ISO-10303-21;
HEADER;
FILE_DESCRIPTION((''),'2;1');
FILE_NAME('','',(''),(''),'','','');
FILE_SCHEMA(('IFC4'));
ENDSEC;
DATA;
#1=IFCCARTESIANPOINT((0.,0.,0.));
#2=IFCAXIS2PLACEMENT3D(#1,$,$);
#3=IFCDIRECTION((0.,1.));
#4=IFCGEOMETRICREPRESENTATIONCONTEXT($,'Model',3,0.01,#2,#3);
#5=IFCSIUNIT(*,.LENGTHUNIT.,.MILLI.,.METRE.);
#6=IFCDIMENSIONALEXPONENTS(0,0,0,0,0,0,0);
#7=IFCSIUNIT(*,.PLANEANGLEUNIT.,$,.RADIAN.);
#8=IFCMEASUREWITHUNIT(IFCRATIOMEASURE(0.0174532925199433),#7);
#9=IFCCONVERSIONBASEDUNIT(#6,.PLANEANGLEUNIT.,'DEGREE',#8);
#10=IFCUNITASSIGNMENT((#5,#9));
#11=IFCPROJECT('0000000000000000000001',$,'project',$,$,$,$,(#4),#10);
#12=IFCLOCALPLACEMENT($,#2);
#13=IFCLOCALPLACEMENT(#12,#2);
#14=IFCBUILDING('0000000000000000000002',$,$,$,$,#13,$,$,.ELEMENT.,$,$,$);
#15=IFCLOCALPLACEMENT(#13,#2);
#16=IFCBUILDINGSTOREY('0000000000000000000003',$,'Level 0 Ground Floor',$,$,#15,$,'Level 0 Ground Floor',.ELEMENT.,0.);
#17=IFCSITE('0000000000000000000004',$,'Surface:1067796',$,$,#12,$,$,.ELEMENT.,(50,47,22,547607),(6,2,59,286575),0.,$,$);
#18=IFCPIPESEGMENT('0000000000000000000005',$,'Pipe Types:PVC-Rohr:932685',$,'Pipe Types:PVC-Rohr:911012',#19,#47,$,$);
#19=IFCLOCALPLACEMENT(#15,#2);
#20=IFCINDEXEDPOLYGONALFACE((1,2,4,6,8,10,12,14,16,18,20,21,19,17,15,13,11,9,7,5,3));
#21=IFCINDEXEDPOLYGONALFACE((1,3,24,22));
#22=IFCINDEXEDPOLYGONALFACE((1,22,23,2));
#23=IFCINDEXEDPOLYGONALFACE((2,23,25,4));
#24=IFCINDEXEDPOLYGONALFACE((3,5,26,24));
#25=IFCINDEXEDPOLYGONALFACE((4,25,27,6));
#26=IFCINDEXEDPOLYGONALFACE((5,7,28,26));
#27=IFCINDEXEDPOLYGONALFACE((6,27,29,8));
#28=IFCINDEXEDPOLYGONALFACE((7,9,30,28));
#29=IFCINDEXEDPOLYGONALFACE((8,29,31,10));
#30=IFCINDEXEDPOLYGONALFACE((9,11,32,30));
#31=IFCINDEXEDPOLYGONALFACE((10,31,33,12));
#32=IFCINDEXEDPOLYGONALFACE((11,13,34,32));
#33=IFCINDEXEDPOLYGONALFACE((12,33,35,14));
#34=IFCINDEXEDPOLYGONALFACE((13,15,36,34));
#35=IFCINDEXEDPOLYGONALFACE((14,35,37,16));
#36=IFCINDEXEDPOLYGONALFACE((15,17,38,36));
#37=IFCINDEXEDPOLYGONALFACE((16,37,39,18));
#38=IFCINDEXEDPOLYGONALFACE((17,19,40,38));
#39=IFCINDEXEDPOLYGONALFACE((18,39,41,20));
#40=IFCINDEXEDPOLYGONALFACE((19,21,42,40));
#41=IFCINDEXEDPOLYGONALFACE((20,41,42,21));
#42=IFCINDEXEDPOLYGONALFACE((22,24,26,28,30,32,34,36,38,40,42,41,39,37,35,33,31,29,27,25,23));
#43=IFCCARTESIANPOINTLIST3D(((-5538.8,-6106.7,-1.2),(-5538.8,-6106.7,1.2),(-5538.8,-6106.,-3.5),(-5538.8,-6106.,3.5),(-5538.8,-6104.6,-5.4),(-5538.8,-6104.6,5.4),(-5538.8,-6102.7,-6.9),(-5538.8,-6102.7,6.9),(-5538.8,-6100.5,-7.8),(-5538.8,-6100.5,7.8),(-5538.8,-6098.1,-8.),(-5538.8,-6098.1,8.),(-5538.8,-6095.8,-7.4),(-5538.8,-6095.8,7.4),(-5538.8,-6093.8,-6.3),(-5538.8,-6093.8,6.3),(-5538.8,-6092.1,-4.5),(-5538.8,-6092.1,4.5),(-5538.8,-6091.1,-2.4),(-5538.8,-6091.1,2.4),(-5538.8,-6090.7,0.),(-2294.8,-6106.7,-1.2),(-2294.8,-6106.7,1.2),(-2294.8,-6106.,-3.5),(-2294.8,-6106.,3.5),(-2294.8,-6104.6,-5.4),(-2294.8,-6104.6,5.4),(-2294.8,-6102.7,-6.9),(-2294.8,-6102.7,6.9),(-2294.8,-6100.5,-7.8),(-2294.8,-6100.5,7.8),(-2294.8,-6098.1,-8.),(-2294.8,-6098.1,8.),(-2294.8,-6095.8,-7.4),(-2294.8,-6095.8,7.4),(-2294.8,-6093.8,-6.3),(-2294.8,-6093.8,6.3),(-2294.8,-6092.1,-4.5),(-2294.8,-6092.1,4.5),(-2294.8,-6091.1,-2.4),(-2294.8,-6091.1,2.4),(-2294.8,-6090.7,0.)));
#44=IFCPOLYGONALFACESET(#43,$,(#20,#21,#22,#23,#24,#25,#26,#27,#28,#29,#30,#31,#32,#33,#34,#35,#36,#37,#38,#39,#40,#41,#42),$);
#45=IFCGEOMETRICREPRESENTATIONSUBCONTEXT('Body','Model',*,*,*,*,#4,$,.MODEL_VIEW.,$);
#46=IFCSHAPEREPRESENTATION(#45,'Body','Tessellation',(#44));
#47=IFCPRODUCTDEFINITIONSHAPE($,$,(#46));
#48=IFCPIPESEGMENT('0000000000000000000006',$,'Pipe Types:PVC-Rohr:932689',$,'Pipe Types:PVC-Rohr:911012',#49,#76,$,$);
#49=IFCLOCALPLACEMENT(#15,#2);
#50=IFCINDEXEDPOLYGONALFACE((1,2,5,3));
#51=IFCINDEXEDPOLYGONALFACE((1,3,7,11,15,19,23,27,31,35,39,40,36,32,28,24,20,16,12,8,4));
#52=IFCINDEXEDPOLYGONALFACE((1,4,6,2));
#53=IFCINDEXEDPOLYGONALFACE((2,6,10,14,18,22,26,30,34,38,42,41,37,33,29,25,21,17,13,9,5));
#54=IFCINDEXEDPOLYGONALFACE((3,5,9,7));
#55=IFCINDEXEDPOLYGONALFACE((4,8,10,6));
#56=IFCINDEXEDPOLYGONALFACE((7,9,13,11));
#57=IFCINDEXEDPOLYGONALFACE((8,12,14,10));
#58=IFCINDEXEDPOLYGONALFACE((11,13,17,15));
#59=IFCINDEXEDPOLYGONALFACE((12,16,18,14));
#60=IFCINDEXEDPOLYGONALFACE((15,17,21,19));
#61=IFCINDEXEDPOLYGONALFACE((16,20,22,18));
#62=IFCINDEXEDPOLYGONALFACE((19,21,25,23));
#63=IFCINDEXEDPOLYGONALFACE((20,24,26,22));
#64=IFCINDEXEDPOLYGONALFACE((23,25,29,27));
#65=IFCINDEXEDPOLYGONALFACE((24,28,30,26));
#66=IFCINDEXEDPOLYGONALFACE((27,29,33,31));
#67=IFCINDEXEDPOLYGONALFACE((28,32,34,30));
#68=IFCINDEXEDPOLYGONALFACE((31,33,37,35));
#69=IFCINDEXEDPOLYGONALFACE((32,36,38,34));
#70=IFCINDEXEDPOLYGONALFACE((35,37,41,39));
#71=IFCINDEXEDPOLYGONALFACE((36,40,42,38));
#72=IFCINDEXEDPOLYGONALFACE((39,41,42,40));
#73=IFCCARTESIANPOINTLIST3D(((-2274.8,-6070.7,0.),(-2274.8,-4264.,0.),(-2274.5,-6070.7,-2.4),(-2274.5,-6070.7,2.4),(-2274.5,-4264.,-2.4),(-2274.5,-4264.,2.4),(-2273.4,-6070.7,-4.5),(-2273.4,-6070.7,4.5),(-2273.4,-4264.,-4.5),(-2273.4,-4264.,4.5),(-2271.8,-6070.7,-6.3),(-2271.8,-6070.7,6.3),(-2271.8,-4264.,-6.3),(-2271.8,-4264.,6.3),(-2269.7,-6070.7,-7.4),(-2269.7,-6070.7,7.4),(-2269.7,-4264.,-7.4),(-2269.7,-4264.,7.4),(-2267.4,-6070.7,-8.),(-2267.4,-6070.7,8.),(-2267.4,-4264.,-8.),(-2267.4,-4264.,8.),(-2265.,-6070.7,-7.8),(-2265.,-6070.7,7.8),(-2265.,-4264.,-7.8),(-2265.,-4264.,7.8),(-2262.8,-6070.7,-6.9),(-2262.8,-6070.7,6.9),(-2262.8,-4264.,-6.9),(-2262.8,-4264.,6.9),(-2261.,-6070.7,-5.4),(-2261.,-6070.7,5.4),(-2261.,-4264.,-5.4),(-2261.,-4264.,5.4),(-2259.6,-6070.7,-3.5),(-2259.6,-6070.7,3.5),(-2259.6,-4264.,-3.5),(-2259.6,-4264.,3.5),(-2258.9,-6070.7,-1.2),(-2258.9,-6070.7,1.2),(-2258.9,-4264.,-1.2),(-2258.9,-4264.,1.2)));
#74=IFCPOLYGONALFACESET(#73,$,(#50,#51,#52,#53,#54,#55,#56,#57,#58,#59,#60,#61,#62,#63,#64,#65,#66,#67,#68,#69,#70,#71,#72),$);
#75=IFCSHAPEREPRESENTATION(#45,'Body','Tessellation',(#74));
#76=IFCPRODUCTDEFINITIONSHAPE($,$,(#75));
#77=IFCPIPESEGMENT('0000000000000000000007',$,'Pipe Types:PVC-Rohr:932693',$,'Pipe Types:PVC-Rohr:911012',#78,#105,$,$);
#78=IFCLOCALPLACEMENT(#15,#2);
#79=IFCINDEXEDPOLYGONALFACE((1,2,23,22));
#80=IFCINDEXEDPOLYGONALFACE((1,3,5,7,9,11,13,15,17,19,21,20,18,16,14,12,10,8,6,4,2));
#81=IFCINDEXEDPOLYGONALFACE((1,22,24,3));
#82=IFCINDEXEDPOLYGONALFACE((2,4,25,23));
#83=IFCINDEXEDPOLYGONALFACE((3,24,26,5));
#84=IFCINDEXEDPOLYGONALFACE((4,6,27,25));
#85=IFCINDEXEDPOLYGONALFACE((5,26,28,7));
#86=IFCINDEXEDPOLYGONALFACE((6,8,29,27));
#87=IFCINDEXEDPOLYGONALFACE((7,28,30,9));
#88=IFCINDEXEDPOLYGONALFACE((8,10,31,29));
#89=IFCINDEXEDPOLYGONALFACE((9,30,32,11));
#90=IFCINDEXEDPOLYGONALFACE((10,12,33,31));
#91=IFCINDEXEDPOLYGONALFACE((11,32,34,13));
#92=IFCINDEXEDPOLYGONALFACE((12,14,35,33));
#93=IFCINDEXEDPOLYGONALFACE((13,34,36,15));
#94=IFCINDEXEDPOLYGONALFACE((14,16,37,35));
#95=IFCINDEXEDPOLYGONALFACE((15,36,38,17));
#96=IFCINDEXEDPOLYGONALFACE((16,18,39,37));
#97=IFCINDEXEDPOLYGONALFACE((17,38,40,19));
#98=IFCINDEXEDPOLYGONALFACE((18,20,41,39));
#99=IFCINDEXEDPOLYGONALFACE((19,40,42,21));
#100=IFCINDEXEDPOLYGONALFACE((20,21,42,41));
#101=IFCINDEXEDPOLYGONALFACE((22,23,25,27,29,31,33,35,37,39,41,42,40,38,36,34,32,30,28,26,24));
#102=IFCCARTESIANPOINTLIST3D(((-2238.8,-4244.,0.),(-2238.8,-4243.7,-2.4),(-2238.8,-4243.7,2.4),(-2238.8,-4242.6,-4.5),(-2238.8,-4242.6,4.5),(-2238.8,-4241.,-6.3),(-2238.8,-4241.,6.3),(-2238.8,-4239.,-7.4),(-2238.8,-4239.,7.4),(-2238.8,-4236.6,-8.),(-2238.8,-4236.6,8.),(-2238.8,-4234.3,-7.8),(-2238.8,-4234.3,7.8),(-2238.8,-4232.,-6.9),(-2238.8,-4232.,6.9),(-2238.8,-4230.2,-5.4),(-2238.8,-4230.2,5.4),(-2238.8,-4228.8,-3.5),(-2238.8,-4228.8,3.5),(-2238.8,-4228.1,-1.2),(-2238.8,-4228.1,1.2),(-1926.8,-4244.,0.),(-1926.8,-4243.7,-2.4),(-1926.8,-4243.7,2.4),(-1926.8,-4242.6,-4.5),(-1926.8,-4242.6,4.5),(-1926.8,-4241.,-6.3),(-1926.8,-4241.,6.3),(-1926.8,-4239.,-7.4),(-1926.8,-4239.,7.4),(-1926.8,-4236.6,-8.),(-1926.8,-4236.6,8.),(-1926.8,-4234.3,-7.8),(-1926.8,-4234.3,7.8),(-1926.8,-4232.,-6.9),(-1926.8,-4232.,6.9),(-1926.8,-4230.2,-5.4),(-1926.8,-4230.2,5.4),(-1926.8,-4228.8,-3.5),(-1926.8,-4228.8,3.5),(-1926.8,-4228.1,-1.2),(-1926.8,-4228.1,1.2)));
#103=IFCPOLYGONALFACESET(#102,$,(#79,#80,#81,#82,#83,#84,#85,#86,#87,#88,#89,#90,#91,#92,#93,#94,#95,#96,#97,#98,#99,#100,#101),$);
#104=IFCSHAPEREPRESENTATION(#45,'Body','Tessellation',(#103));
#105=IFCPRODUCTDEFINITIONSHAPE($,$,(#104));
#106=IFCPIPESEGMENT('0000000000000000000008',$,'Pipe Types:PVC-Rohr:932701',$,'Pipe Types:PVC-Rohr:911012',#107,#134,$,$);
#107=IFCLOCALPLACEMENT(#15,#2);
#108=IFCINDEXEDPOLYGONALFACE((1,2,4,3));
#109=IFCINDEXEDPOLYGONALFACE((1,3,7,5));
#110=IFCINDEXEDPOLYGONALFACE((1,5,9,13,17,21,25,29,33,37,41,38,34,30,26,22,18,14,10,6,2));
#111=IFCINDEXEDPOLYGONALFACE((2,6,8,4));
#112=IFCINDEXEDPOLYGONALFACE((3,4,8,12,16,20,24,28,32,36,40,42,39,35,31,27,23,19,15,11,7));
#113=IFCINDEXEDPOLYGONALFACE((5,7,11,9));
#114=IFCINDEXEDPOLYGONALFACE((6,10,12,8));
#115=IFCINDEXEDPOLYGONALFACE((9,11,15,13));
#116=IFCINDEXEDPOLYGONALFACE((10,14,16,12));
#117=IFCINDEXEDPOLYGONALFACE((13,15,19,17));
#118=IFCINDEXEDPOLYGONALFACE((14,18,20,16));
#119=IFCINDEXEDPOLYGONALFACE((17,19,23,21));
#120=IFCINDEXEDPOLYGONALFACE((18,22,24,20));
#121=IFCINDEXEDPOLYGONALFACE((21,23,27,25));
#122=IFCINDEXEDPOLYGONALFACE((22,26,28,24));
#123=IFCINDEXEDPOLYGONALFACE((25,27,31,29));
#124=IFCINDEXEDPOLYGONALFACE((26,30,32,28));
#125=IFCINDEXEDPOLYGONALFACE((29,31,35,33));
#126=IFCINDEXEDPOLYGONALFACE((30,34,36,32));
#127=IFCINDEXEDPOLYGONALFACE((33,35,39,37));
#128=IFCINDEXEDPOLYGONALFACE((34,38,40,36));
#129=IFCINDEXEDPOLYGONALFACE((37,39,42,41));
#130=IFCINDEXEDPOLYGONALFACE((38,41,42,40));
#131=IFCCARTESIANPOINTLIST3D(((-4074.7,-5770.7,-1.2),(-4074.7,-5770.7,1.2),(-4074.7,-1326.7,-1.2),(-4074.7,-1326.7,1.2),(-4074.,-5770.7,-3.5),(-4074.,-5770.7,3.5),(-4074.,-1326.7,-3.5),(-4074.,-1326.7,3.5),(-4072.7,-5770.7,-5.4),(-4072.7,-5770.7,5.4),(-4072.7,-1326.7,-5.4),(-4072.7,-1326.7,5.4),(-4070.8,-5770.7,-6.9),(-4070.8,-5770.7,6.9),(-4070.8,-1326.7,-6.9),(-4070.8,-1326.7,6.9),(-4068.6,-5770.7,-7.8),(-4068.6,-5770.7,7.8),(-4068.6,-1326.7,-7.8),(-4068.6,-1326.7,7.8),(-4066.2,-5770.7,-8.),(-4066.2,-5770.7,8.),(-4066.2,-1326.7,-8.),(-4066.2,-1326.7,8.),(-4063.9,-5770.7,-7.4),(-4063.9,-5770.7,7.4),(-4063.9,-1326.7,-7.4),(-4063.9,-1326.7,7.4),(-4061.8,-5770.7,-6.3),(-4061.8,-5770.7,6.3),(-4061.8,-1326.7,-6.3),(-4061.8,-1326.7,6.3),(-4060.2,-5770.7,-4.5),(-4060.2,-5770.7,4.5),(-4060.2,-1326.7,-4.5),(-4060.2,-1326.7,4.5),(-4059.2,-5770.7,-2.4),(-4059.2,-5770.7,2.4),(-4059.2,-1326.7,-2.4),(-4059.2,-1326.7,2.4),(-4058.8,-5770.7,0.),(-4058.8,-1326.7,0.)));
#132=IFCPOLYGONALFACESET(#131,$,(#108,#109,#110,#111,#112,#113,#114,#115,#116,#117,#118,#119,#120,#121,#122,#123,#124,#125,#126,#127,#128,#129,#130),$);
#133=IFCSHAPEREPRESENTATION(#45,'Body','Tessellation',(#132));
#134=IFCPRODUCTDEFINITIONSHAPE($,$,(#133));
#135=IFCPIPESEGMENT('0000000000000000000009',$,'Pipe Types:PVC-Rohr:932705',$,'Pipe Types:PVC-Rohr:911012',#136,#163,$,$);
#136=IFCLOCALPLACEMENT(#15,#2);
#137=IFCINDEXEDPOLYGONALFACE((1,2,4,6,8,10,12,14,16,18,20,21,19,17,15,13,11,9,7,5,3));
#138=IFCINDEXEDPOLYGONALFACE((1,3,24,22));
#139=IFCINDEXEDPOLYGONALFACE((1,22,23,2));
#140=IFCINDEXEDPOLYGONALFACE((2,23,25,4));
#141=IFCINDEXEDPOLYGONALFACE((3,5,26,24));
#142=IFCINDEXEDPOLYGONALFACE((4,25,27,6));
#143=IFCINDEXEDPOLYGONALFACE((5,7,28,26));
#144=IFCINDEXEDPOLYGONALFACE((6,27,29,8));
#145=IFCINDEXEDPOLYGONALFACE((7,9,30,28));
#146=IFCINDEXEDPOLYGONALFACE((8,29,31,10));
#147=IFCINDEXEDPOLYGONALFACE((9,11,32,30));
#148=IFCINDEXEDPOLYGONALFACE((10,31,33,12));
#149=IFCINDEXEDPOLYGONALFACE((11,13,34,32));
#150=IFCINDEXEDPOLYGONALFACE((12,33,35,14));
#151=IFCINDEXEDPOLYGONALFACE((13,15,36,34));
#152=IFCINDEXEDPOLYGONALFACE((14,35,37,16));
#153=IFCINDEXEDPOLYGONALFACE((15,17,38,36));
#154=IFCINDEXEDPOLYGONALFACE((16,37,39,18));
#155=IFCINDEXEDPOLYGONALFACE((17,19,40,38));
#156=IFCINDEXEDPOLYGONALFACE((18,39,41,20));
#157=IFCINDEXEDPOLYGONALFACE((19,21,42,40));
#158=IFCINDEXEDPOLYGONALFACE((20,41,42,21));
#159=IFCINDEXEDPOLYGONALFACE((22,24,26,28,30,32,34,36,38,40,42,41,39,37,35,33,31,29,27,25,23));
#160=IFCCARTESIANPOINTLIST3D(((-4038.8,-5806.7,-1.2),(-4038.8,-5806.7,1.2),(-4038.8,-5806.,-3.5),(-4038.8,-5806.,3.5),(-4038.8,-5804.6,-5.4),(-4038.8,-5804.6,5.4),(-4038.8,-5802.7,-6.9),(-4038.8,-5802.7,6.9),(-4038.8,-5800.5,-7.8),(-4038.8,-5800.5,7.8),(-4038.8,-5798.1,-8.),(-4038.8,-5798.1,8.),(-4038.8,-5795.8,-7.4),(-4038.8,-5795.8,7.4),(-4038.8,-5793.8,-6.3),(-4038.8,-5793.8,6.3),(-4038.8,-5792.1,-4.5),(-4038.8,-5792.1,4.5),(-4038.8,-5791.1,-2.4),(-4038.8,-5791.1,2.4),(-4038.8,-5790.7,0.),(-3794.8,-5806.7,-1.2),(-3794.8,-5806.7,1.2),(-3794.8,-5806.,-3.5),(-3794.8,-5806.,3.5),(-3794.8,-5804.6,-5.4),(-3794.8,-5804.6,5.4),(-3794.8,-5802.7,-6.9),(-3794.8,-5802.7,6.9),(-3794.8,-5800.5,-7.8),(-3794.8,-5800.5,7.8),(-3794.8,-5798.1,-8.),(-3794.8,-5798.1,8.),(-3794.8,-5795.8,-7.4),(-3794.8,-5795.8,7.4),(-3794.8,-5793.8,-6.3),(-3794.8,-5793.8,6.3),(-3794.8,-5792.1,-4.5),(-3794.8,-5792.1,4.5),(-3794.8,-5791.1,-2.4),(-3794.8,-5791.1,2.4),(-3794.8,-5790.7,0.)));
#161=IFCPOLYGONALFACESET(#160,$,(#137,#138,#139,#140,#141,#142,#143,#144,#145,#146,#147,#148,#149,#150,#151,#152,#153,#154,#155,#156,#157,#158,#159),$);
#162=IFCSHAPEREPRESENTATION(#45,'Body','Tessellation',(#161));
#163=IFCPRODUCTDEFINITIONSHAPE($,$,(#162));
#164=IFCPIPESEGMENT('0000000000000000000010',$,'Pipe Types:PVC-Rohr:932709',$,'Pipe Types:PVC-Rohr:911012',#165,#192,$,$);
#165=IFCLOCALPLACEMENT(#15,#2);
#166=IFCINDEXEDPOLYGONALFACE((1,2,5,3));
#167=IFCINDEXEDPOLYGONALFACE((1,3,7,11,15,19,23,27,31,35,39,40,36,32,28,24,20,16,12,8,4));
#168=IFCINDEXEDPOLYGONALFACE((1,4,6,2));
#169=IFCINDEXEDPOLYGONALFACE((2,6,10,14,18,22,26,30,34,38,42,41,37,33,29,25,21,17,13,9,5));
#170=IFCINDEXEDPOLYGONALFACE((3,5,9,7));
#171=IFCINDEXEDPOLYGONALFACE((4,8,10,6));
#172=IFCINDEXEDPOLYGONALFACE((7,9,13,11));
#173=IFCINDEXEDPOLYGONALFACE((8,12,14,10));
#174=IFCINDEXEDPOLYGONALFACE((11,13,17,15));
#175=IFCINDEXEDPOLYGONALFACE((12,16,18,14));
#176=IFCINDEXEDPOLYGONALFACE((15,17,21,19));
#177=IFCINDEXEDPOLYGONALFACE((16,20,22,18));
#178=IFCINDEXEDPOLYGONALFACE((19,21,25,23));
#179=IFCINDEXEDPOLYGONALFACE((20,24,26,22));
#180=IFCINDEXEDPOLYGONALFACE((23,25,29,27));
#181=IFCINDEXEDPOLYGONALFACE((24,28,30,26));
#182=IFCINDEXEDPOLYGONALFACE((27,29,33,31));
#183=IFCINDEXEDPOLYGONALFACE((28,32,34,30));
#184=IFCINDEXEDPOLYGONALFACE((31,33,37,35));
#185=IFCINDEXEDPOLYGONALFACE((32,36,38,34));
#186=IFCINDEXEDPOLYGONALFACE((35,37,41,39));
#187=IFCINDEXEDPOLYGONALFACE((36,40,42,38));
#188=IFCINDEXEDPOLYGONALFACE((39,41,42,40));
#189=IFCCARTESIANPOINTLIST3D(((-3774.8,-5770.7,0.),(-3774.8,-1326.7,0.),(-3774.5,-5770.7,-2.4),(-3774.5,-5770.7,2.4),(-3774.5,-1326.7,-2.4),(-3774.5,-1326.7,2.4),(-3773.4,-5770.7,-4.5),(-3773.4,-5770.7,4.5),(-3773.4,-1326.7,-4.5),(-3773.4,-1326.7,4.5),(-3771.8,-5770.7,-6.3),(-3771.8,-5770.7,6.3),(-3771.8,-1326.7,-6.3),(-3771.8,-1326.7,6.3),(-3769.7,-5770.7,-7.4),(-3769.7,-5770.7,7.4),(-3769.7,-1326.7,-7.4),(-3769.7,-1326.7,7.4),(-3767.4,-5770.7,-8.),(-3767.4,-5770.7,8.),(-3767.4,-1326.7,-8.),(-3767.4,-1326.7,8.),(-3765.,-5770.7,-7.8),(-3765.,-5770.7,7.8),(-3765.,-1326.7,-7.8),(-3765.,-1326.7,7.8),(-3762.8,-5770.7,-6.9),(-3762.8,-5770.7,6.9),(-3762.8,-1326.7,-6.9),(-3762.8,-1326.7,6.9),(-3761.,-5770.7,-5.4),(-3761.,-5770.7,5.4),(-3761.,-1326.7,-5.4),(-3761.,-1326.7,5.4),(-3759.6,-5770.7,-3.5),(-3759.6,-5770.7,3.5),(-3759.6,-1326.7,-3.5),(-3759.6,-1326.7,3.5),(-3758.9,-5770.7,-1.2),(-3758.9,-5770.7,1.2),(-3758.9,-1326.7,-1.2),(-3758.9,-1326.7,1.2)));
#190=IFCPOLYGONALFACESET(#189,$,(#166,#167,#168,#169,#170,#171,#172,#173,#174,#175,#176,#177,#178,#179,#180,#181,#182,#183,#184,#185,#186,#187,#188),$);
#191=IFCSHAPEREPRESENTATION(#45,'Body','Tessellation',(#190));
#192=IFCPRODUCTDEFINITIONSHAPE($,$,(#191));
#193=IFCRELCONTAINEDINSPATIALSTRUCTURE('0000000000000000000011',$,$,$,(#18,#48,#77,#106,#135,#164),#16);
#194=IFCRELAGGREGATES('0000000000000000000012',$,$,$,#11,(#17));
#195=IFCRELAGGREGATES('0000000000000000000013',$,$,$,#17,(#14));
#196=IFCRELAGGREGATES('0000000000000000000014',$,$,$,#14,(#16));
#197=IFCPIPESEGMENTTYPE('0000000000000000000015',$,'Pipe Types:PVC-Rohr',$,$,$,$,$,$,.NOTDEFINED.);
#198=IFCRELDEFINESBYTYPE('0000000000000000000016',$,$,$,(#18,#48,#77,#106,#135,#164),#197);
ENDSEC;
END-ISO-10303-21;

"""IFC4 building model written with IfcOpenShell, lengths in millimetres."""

from ifc_helpers import new_model, entity, si_unit, converted_unit, direction, frame, frame_2d, origin, place, context, subcontext, project, spatial, circle, extrude, type_object, element, save


model = new_model("IFC4")

# Units and contexts
model_context = context("Model", 3, precision=0.01, world=origin(), true_north=direction((0.0, 1.0)))
body_context = subcontext(model_context, "Body", "Model", "MODEL_VIEW")
ifc_project = project(units=[si_unit("LENGTHUNIT", "METRE", prefix="MILLI"), converted_unit("PLANEANGLEUNIT", "DEGREE", entity("IfcRatioMeasure", 0.0174532925199433), si_unit("PLANEANGLEUNIT", "RADIAN"), dimensions=[0, 0, 0, 0, 0, 0, 0])], contexts=[model_context])

# Site, building, storey
site_placement = place(None, origin())
site = spatial("IfcSite", under=ifc_project, at=site_placement, Name="Surface:1067796", CompositionType="ELEMENT", RefLatitude=(50, 47, 22, 547607), RefLongitude=(6, 2, 59, 286575), RefElevation=0.0)
building_placement = place(site_placement, origin())
building = spatial("IfcBuilding", under=site, at=building_placement, CompositionType="ELEMENT")
storey_placement = place(building_placement, origin())
storey = spatial("IfcBuildingStorey", under=building, at=storey_placement, Name="Level 0 Ground Floor", LongName="Level 0 Ground Floor", CompositionType="ELEMENT", Elevation=0.0)

# Pipe segments
pipe_segment_type_1 = type_object("IfcPipeSegmentType", Name="Pipe Types:PVC-Rohr", PredefinedType="NOTDEFINED")
pipe_segment_1_placement = place(storey_placement, frame((-5538.8, -6108.3, -9.6)))
element("IfcPipeSegment", 1, at=pipe_segment_1_placement, inside=storey, type_object=pipe_segment_type_1, Name="Pipe Types:PVC-Rohr:932685", ObjectType="Pipe Types:PVC-Rohr:911012", context=body_context, shape_type="SweptSolid", body=[
    extrude(circle(Radius=8.0, at=frame_2d((0.0, 0.0), x_axis=(1.0, 0.0))), frame((0.0, 9.6, 9.6), z_axis=(1.0, 0.0, 0.0), x_axis=(0.0, 1.0, 0.0)), (0.0, 0.0, 1.0), 3244.0),
])
pipe_segment_2_placement = place(storey_placement, frame((-2276.4, -6070.7, -9.6)))
element("IfcPipeSegment", 2, at=pipe_segment_2_placement, inside=storey, type_object=pipe_segment_type_1, Name="Pipe Types:PVC-Rohr:932689", ObjectType="Pipe Types:PVC-Rohr:911012", context=body_context, shape_type="SweptSolid", body=[
    extrude(circle(Radius=8.0, at=frame_2d((0.0, 0.0), x_axis=(1.0, 0.0))), frame((9.6, 0.0, 9.6), z_axis=(0.0, 1.0, 0.0), x_axis=(-1.0, 0.0, 0.0)), (0.0, 0.0, 1.0), 1806.7),
])
pipe_segment_3_placement = place(storey_placement, frame((-2238.8, -4245.6, -9.6)))
element("IfcPipeSegment", 3, at=pipe_segment_3_placement, inside=storey, type_object=pipe_segment_type_1, Name="Pipe Types:PVC-Rohr:932693", ObjectType="Pipe Types:PVC-Rohr:911012", context=body_context, shape_type="SweptSolid", body=[
    extrude(circle(Radius=8.0, at=frame_2d((0.0, 0.0), x_axis=(1.0, 0.0))), frame((0.0, 9.6, 9.6), z_axis=(1.0, 0.0, 0.0), x_axis=(0.0, -1.0, 0.0)), (0.0, 0.0, 1.0), 312.0),
])
pipe_segment_4_placement = place(storey_placement, frame((-4076.4, -5770.7, -9.6)))
element("IfcPipeSegment", 4, at=pipe_segment_4_placement, inside=storey, type_object=pipe_segment_type_1, Name="Pipe Types:PVC-Rohr:932701", ObjectType="Pipe Types:PVC-Rohr:911012", context=body_context, shape_type="SweptSolid", body=[
    extrude(circle(Radius=8.0, at=frame_2d((0.0, 0.0), x_axis=(1.0, 0.0))), frame((9.6, 0.0, 9.6), z_axis=(0.0, 1.0, 0.0), x_axis=(1.0, 0.0, 0.0)), (0.0, 0.0, 1.0), 4444.0),
])
pipe_segment_5_placement = place(storey_placement, frame((-4038.8, -5808.3, -9.6)))
element("IfcPipeSegment", 5, at=pipe_segment_5_placement, inside=storey, type_object=pipe_segment_type_1, Name="Pipe Types:PVC-Rohr:932705", ObjectType="Pipe Types:PVC-Rohr:911012", context=body_context, shape_type="SweptSolid", body=[
    extrude(circle(Radius=8.0, at=frame_2d((0.0, 0.0), x_axis=(1.0, 0.0))), frame((0.0, 9.6, 9.6), z_axis=(1.0, 0.0, 0.0), x_axis=(0.0, 1.0, 0.0)), (0.0, 0.0, 1.0), 244.0),
])
pipe_segment_6_placement = place(storey_placement, frame((-3776.4, -5770.7, -9.6)))
element("IfcPipeSegment", 6, at=pipe_segment_6_placement, inside=storey, type_object=pipe_segment_type_1, Name="Pipe Types:PVC-Rohr:932709", ObjectType="Pipe Types:PVC-Rohr:911012", context=body_context, shape_type="SweptSolid", body=[
    extrude(circle(Radius=8.0, at=frame_2d((0.0, 0.0), x_axis=(1.0, 0.0))), frame((9.6, 0.0, 9.6), z_axis=(0.0, 1.0, 0.0), x_axis=(-1.0, 0.0, 0.0)), (0.0, 0.0, 1.0), 4444.0),
])

save(model, "model.ifc")
